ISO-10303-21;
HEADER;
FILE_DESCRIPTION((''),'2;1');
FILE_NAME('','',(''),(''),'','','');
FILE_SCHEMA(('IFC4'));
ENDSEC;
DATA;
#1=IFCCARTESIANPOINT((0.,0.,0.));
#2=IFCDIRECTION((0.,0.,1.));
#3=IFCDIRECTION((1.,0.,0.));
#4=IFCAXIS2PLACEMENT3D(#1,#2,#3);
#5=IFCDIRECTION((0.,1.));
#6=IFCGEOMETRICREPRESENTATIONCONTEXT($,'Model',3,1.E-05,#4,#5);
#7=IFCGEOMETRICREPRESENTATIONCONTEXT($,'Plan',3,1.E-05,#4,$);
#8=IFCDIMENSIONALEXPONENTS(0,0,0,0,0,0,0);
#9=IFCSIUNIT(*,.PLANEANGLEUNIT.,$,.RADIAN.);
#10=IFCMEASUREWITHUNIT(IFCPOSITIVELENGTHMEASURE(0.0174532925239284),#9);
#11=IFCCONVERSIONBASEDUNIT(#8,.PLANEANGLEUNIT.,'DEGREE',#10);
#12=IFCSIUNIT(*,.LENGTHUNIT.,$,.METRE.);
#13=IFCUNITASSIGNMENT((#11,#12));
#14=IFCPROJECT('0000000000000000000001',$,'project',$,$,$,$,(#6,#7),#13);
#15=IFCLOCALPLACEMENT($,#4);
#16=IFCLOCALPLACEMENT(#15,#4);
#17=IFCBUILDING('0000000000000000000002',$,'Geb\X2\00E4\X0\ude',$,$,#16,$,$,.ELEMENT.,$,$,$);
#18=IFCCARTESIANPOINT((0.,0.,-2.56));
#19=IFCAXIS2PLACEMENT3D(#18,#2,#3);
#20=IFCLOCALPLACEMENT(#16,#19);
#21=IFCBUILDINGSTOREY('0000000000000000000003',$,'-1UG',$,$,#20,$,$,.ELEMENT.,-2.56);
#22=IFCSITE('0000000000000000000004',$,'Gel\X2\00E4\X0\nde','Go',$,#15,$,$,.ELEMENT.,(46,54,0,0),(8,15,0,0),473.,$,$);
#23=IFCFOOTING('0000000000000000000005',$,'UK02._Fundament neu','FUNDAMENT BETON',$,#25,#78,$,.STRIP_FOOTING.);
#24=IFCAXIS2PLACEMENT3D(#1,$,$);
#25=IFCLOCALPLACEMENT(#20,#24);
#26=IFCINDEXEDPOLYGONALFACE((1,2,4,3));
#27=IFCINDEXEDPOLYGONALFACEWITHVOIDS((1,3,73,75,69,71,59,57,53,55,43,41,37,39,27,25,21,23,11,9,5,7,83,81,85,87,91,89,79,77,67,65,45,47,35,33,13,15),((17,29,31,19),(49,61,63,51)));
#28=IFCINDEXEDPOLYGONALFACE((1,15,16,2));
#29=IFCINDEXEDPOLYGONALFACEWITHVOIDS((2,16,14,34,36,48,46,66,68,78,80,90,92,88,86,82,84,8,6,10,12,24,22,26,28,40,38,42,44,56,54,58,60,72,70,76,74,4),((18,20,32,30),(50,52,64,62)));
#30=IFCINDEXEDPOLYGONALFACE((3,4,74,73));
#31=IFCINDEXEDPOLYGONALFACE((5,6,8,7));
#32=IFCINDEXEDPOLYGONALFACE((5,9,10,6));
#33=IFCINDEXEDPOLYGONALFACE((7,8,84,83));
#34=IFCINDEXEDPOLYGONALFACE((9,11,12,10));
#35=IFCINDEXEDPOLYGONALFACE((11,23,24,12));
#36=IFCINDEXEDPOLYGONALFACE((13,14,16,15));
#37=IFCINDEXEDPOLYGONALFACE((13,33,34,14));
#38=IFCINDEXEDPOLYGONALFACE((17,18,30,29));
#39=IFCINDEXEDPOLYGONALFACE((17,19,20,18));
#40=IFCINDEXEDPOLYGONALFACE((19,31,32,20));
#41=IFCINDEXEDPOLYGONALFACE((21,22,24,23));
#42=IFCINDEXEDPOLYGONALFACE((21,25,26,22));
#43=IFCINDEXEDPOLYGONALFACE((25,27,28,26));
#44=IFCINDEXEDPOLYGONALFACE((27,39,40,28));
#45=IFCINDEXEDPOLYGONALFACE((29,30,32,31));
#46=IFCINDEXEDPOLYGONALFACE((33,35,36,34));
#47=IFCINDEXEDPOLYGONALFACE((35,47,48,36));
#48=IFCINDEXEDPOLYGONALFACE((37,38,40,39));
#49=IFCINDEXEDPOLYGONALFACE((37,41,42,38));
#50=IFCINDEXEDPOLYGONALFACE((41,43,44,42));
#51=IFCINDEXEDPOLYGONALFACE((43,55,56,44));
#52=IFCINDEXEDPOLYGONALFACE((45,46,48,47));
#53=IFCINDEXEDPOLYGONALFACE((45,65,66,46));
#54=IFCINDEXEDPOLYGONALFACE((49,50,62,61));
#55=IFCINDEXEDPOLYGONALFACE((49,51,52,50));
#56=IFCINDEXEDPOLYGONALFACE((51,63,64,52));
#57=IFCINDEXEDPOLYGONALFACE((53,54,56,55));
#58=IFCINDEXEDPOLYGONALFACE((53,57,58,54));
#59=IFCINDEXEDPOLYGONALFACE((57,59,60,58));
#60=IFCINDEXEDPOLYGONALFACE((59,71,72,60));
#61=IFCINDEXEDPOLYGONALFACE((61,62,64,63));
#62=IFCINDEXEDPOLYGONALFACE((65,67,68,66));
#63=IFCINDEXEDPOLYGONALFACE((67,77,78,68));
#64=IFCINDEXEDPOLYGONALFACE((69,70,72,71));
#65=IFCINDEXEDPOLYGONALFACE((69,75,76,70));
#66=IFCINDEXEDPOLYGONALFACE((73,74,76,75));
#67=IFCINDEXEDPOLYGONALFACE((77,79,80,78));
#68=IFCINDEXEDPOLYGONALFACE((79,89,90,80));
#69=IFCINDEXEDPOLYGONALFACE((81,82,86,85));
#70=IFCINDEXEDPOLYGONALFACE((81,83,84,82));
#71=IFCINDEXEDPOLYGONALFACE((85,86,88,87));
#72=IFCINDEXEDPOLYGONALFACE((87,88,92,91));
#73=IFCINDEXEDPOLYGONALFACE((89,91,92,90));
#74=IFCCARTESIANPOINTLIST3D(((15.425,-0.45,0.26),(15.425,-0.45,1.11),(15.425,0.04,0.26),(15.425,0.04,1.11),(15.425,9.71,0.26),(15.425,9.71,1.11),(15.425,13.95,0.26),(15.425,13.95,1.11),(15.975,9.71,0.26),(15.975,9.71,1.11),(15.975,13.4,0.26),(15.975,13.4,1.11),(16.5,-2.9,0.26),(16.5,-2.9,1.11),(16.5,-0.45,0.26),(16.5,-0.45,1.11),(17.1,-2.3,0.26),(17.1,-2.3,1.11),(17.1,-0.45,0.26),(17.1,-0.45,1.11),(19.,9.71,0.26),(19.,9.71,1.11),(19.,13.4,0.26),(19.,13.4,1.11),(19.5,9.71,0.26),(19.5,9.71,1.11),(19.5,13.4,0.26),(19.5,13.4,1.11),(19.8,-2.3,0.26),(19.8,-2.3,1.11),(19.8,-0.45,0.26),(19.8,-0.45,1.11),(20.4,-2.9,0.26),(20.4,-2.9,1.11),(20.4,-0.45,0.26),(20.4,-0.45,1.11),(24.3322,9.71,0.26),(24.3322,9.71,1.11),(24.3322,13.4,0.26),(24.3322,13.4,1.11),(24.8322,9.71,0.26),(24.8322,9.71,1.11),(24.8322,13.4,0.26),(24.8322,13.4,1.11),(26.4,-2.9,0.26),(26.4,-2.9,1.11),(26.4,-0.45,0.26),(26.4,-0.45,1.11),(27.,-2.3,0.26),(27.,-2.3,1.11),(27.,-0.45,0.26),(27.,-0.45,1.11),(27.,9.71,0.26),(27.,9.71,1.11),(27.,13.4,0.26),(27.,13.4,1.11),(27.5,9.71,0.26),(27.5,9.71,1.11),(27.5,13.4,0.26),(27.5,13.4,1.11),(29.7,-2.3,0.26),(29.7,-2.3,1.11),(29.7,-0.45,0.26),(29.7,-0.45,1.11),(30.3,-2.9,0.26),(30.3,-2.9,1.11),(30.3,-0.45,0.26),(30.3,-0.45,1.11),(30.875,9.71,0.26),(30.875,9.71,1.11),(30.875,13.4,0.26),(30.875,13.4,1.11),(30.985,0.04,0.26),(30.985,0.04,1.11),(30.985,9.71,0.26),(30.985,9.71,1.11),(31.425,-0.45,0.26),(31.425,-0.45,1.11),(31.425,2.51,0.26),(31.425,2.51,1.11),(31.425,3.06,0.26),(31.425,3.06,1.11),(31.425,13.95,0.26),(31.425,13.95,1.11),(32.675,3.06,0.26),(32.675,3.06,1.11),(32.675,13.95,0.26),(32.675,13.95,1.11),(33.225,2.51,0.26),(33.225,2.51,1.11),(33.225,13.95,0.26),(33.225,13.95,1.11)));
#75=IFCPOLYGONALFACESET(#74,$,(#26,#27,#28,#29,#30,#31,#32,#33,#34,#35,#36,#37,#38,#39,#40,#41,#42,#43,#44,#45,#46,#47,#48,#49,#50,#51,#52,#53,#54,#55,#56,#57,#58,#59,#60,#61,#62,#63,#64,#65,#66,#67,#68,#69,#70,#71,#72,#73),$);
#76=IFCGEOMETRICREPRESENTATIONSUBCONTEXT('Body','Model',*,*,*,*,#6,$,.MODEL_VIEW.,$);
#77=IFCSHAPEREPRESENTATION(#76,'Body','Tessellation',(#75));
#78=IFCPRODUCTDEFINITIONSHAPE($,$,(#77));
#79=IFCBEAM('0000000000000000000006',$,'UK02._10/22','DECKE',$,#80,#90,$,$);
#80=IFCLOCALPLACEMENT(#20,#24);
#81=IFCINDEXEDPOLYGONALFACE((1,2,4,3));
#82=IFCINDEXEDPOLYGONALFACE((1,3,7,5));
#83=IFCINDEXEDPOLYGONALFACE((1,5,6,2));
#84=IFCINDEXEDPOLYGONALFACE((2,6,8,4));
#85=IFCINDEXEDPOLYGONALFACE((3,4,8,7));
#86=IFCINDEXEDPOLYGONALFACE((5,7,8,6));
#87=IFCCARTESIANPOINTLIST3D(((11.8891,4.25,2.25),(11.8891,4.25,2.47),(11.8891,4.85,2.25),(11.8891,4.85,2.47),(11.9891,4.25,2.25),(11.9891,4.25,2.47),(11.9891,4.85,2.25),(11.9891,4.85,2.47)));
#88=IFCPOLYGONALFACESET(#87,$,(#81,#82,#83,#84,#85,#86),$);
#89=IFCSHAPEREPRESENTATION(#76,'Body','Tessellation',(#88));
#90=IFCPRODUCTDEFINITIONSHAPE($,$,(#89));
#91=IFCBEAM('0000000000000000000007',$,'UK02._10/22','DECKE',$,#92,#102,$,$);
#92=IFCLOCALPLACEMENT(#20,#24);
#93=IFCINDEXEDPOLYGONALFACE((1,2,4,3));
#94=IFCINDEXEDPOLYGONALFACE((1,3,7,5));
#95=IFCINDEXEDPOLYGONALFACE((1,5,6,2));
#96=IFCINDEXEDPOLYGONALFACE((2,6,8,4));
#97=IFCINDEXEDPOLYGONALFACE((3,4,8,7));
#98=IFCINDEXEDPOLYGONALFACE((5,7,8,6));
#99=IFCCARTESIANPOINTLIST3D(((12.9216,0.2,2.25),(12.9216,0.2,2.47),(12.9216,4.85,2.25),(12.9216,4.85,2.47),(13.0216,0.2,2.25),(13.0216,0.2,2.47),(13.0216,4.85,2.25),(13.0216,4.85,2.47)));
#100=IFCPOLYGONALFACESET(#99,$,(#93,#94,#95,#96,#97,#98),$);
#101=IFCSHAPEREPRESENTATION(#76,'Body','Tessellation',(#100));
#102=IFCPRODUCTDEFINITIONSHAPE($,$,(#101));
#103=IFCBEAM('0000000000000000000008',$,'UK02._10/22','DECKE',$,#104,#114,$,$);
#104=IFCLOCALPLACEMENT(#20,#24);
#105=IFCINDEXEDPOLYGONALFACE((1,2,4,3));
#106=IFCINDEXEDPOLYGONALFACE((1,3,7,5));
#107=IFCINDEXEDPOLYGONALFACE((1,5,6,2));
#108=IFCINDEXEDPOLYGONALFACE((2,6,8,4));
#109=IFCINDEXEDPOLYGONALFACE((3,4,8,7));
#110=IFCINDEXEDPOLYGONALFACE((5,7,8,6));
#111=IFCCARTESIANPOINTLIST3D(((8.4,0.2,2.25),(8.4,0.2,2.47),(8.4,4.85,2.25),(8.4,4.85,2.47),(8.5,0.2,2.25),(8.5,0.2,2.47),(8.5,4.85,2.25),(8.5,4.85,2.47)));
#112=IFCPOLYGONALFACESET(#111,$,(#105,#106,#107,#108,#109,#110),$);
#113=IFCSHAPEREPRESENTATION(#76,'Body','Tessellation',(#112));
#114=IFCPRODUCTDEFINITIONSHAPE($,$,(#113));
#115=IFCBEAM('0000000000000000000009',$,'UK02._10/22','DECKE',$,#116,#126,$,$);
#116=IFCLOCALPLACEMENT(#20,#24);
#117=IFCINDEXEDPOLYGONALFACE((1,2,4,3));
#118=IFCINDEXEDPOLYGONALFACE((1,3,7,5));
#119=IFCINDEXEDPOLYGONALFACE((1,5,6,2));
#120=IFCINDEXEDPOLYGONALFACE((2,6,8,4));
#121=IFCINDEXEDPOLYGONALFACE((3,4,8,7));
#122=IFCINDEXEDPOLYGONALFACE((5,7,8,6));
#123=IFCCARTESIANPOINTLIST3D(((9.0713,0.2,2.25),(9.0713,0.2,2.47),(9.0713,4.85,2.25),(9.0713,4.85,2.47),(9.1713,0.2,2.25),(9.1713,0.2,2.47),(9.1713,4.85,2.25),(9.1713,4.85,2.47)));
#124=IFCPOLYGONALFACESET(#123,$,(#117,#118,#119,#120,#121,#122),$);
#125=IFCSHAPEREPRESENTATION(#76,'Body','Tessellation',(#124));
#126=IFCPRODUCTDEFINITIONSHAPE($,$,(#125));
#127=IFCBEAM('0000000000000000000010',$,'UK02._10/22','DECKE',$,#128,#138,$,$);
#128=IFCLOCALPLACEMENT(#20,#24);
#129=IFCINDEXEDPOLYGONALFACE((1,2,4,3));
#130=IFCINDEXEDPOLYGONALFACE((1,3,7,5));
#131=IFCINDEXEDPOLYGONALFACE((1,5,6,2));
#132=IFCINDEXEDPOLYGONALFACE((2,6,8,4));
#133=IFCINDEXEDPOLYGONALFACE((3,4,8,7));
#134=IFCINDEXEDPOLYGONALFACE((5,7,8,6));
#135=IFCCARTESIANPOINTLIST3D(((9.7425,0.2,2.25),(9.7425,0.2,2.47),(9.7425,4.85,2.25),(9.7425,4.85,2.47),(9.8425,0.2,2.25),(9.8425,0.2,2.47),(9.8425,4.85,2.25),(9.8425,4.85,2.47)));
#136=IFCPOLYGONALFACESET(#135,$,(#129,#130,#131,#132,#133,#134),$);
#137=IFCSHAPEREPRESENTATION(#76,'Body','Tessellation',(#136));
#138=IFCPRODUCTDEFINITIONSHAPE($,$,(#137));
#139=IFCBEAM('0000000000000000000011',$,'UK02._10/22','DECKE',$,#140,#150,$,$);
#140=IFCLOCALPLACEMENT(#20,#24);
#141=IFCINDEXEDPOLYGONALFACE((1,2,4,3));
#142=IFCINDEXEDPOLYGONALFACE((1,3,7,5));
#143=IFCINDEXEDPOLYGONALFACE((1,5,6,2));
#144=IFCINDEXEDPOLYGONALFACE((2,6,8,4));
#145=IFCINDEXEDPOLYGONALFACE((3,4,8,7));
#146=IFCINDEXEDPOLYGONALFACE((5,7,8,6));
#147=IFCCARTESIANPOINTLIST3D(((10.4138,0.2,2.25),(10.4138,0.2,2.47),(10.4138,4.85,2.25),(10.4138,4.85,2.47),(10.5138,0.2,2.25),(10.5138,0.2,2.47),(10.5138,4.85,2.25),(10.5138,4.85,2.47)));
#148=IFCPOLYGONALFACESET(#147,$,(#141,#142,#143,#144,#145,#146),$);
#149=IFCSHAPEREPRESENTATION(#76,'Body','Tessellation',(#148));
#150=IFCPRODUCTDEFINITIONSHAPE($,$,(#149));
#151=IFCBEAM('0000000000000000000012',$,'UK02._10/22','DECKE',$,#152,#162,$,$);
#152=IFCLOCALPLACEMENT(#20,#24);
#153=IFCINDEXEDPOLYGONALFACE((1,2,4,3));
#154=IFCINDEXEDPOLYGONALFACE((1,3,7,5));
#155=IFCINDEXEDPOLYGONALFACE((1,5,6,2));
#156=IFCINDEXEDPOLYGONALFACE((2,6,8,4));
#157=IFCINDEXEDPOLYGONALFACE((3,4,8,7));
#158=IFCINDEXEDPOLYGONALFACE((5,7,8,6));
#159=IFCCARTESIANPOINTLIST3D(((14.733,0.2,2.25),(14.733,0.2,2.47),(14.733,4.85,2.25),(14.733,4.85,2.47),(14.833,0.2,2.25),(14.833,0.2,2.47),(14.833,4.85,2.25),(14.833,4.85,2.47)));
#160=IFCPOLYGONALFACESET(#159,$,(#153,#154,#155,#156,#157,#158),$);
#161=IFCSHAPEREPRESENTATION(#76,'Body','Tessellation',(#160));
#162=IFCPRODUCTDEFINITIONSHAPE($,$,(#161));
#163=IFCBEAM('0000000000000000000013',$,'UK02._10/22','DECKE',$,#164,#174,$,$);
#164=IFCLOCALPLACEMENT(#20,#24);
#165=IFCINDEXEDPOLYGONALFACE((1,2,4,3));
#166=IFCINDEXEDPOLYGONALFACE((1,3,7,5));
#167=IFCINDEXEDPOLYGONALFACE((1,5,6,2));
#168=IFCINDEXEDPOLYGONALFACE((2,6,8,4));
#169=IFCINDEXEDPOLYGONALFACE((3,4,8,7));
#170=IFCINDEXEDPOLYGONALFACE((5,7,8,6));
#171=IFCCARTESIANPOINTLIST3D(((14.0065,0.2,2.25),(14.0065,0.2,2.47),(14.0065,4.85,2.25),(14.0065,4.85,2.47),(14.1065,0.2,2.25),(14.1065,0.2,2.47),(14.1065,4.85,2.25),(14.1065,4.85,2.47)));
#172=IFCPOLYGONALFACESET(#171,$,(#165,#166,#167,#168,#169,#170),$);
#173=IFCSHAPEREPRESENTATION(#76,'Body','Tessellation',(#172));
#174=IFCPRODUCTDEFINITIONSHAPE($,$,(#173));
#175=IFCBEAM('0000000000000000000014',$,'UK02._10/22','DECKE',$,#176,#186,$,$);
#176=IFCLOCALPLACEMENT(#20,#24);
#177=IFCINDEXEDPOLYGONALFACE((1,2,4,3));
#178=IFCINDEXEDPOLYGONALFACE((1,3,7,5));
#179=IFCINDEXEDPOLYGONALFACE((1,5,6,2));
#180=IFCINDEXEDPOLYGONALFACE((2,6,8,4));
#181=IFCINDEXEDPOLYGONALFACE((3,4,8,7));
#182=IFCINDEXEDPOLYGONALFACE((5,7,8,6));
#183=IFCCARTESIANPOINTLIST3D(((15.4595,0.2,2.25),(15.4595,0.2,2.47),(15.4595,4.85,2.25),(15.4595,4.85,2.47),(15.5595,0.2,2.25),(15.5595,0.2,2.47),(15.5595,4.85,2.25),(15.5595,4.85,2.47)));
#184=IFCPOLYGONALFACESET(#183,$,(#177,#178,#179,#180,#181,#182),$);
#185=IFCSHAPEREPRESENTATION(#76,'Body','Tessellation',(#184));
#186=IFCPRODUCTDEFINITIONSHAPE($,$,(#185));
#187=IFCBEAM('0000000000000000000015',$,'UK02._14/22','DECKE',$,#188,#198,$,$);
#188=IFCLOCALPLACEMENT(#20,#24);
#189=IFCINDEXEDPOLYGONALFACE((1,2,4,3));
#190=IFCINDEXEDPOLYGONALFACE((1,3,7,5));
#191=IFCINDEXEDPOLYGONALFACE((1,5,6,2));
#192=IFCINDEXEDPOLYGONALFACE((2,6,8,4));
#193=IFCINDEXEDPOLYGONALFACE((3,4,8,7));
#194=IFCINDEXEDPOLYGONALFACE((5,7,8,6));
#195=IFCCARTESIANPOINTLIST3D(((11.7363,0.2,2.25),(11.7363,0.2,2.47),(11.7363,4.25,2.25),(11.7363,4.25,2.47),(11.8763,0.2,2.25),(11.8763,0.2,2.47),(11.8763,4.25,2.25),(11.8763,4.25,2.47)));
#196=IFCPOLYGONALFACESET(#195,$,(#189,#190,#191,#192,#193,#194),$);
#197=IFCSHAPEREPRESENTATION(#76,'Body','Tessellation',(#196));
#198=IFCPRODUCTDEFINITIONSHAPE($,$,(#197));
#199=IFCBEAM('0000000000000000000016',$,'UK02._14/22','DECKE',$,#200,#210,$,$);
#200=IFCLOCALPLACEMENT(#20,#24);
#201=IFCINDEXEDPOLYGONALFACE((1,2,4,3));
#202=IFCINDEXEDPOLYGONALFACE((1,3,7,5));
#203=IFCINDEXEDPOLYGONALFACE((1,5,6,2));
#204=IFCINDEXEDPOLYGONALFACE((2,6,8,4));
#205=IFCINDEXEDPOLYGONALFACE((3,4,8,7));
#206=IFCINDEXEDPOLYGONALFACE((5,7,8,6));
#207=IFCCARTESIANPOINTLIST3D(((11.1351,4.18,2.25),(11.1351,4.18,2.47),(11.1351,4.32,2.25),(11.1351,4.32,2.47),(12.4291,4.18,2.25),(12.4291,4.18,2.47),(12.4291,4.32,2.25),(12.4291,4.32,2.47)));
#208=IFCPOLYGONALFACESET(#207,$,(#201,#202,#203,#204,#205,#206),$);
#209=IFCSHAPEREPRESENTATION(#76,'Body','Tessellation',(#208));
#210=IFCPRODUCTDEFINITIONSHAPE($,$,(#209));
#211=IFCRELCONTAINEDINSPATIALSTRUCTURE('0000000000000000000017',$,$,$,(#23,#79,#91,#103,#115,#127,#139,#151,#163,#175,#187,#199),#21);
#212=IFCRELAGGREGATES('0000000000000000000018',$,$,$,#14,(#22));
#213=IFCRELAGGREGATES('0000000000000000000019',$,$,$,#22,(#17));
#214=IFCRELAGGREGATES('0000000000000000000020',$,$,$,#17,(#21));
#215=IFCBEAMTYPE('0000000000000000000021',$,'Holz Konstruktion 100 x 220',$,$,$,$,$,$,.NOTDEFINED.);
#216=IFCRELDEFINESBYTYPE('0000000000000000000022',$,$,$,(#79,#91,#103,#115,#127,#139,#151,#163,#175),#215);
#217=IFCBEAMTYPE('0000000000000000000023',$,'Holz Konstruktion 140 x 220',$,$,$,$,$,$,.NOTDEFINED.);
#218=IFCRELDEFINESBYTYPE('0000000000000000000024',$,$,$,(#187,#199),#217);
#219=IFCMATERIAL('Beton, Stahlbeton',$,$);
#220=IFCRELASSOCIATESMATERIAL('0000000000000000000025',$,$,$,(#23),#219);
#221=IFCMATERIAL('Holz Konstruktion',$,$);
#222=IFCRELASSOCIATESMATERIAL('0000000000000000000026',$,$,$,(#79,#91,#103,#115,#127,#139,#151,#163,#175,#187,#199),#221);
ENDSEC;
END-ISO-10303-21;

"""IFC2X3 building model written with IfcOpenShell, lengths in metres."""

from ifc_helpers import new_model, entity, si_unit, converted_unit, direction, frame, frame_2d, origin_with_axes, place, context, subcontext, project, spatial, polyline, rectangle, outline, extrude, material, type_object, element, save


model = new_model("IFC2X3")

# Units and contexts
model_context = context("Model", 3, precision=1e-05, world=origin_with_axes(), true_north=direction((0.0, 1.0)))
plan_context = context("Plan", 3, precision=1e-05, world=origin_with_axes())
body_context = subcontext(model_context, "Body", "Model", "MODEL_VIEW")
ifc_project = project(units=[converted_unit("PLANEANGLEUNIT", "DEGREE", entity("IfcPositiveLengthMeasure", 0.0174532925239284), si_unit("PLANEANGLEUNIT", "RADIAN"), dimensions=[0, 0, 0, 0, 0, 0, 0]), si_unit("LENGTHUNIT", "METRE")], contexts=[model_context, plan_context])

# Site, building, storey
site_placement = place(None, origin_with_axes())
site = spatial("IfcSite", under=ifc_project, at=site_placement, Name="Gelände", Description="Go", CompositionType="ELEMENT", RefLatitude=(46, 54, 0, 0), RefLongitude=(8, 15, 0, 0), RefElevation=473.0)
building_placement = place(site_placement, origin_with_axes())
building = spatial("IfcBuilding", under=site, at=building_placement, Name="Gebäude", CompositionType="ELEMENT")
storey_placement = place(building_placement, frame((0.0, 0.0, -2.56), z_axis=(0.0, 0.0, 1.0), x_axis=(1.0, 0.0, 0.0)))
storey = spatial("IfcBuildingStorey", under=building, at=storey_placement, Name="-1UG", CompositionType="ELEMENT", Elevation=-2.56)

# Footing
ifc_material_1 = material(Name="Beton, Stahlbeton")
footing_placement = place(storey_placement, frame((15.425, 0.04, 1.11), z_axis=(0.0, 0.0, 1.0), x_axis=(1.0, 0.0, 0.0)))
element("IfcFooting", 1, at=footing_placement, inside=storey, material=ifc_material_1, Name="UK02._Fundament neu", Description="FUNDAMENT BETON", PredefinedType="STRIP_FOOTING", context=body_context, shape_type="SweptSolid", body=[
    extrude(outline(polyline([(0.0, 0.0), (0.0, -0.49), (1.075, -0.49), (1.075, -2.94), (4.975, -2.94), (4.975, -0.49), (10.975, -0.49), (10.975, -2.94), (14.875, -2.94), (14.875, -0.49), (16.0, -0.49), (16.0, 2.47), (17.8, 2.47), (17.8, 13.91), (17.25, 13.91), (17.25, 3.02), (16.0, 3.02), (16.0, 13.91), (0.0, 13.91), (0.0, 9.67), (0.55, 9.67), (0.55, 13.36), (3.575, 13.36), (3.575, 9.67), (4.075, 9.67), (4.075, 13.36), (8.9072, 13.36), (8.9072, 9.67), (9.4072, 9.67), (9.4072, 13.36), (11.575, 13.36), (11.575, 9.67), (12.075, 9.67), (12.075, 13.36), (15.45, 13.36), (15.45, 9.67), (15.56, 9.67), (15.56, 0.0), (0.0, 0.0)]), holes=[polyline([(4.375, -2.34), (1.675, -2.34), (1.675, -0.49), (4.375, -0.49), (4.375, -2.34)]), polyline([(14.275, -2.34), (11.575, -2.34), (11.575, -0.49), (14.275, -0.49), (14.275, -2.34)])]), frame((0.0, 0.0, -0.85), z_axis=(0.0, 0.0, 1.0), x_axis=(1.0, 0.0, 0.0)), (0.0, 0.0, 1.0), 0.85),
])

# Beams
ifc_material_2 = material(Name="Holz Konstruktion")
beam_type_1 = type_object("IfcBeamType", Name="Holz Konstruktion 100 x 220", PredefinedType="NOTDEFINED")
beam_1_placement = place(storey_placement, frame((11.9391, 4.25, 2.47), z_axis=(0.0, 0.0, 1.0), x_axis=(1.0, 0.0, 0.0)))
element("IfcBeam", 2, at=beam_1_placement, inside=storey, type_object=beam_type_1, material=ifc_material_2, Name="UK02._10/22", Description="DECKE", context=body_context, shape_type="SweptSolid", body=[
    extrude(rectangle(XDim=0.22, YDim=0.1, at=frame_2d((-0.11, 0.0), x_axis=(1.0, 0.0))), frame((0.0, 0.0, 0.0), z_axis=(0.0, 1.0, 0.0), x_axis=(0.0, 0.0, 1.0)), (0.0, 0.0, 1.0), 0.6),
])
for number, where, z_axis, x_axis, name in (
    (3, (12.9716, 0.2, 2.47), (0.0, 0.0, 1.0), (1.0, 0.0, 0.0), "UK02._10/22"),
    (4, (8.45, 0.2, 2.47), (0.0, 0.0, 1.0), (1.0, 0.0, 0.0), "UK02._10/22"),
    (5, (9.1213, 0.2, 2.47), (0.0, 0.0, 1.0), (1.0, 0.0, 0.0), "UK02._10/22"),
    (6, (9.7925, 0.2, 2.47), (0.0, 0.0, 1.0), (1.0, 0.0, 0.0), "UK02._10/22"),
    (7, (10.4638, 0.2, 2.47), (0.0, 0.0, 1.0), (1.0, 0.0, 0.0), "UK02._10/22"),
    (8, (14.783, 0.2, 2.47), (0.0, 0.0, 1.0), (1.0, 0.0, 0.0), "UK02._10/22"),
    (9, (14.0565, 0.2, 2.47), (0.0, 0.0, 1.0), (1.0, 0.0, 0.0), "UK02._10/22"),
    (10, (15.5095, 0.2, 2.47), (0.0, 0.0, 1.0), (1.0, 0.0, 0.0), "UK02._10/22"),
):
    element("IfcBeam", number, at=place(storey_placement, frame(where, z_axis=z_axis, x_axis=x_axis)), inside=storey, type_object=beam_type_1, material=ifc_material_2, Name=name, Description="DECKE", context=body_context, shape_type="SweptSolid", body=[
        extrude(rectangle(XDim=0.22, YDim=0.1, at=frame_2d((-0.11, 0.0), x_axis=(1.0, 0.0))), frame((0.0, 0.0, 0.0), z_axis=(0.0, 1.0, 0.0), x_axis=(0.0, 0.0, 1.0)), (0.0, 0.0, 1.0), 4.65),
    ])
beam_type_2 = type_object("IfcBeamType", Name="Holz Konstruktion 140 x 220", PredefinedType="NOTDEFINED")
beam_2_placement = place(storey_placement, frame((11.8063, 0.2, 2.47), z_axis=(0.0, 0.0, 1.0), x_axis=(1.0, 0.0, 0.0)))
element("IfcBeam", 11, at=beam_2_placement, inside=storey, type_object=beam_type_2, material=ifc_material_2, Name="UK02._14/22", Description="DECKE", context=body_context, shape_type="SweptSolid", body=[
    extrude(rectangle(XDim=0.22, YDim=0.14, at=frame_2d((-0.11, 0.0), x_axis=(1.0, 0.0))), frame((0.0, 0.0, 0.0), z_axis=(0.0, 1.0, 0.0), x_axis=(0.0, 0.0, 1.0)), (0.0, 0.0, 1.0), 4.05),
])
beam_3_placement = place(storey_placement, frame((12.4291, 4.25, 2.47), z_axis=(0.0, 0.0, 1.0), x_axis=(0.0, 1.0, 0.0)))
element("IfcBeam", 12, at=beam_3_placement, inside=storey, type_object=beam_type_2, material=ifc_material_2, Name="UK02._14/22", Description="DECKE", context=body_context, shape_type="SweptSolid", body=[
    extrude(rectangle(XDim=0.22, YDim=0.14, at=frame_2d((-0.11, 0.0), x_axis=(1.0, 0.0))), frame((0.0, 0.0, 0.0), z_axis=(0.0, 1.0, 0.0), x_axis=(0.0, 0.0, 1.0)), (0.0, 0.0, 1.0), 1.294),
])

save(model, "model.ifc")
